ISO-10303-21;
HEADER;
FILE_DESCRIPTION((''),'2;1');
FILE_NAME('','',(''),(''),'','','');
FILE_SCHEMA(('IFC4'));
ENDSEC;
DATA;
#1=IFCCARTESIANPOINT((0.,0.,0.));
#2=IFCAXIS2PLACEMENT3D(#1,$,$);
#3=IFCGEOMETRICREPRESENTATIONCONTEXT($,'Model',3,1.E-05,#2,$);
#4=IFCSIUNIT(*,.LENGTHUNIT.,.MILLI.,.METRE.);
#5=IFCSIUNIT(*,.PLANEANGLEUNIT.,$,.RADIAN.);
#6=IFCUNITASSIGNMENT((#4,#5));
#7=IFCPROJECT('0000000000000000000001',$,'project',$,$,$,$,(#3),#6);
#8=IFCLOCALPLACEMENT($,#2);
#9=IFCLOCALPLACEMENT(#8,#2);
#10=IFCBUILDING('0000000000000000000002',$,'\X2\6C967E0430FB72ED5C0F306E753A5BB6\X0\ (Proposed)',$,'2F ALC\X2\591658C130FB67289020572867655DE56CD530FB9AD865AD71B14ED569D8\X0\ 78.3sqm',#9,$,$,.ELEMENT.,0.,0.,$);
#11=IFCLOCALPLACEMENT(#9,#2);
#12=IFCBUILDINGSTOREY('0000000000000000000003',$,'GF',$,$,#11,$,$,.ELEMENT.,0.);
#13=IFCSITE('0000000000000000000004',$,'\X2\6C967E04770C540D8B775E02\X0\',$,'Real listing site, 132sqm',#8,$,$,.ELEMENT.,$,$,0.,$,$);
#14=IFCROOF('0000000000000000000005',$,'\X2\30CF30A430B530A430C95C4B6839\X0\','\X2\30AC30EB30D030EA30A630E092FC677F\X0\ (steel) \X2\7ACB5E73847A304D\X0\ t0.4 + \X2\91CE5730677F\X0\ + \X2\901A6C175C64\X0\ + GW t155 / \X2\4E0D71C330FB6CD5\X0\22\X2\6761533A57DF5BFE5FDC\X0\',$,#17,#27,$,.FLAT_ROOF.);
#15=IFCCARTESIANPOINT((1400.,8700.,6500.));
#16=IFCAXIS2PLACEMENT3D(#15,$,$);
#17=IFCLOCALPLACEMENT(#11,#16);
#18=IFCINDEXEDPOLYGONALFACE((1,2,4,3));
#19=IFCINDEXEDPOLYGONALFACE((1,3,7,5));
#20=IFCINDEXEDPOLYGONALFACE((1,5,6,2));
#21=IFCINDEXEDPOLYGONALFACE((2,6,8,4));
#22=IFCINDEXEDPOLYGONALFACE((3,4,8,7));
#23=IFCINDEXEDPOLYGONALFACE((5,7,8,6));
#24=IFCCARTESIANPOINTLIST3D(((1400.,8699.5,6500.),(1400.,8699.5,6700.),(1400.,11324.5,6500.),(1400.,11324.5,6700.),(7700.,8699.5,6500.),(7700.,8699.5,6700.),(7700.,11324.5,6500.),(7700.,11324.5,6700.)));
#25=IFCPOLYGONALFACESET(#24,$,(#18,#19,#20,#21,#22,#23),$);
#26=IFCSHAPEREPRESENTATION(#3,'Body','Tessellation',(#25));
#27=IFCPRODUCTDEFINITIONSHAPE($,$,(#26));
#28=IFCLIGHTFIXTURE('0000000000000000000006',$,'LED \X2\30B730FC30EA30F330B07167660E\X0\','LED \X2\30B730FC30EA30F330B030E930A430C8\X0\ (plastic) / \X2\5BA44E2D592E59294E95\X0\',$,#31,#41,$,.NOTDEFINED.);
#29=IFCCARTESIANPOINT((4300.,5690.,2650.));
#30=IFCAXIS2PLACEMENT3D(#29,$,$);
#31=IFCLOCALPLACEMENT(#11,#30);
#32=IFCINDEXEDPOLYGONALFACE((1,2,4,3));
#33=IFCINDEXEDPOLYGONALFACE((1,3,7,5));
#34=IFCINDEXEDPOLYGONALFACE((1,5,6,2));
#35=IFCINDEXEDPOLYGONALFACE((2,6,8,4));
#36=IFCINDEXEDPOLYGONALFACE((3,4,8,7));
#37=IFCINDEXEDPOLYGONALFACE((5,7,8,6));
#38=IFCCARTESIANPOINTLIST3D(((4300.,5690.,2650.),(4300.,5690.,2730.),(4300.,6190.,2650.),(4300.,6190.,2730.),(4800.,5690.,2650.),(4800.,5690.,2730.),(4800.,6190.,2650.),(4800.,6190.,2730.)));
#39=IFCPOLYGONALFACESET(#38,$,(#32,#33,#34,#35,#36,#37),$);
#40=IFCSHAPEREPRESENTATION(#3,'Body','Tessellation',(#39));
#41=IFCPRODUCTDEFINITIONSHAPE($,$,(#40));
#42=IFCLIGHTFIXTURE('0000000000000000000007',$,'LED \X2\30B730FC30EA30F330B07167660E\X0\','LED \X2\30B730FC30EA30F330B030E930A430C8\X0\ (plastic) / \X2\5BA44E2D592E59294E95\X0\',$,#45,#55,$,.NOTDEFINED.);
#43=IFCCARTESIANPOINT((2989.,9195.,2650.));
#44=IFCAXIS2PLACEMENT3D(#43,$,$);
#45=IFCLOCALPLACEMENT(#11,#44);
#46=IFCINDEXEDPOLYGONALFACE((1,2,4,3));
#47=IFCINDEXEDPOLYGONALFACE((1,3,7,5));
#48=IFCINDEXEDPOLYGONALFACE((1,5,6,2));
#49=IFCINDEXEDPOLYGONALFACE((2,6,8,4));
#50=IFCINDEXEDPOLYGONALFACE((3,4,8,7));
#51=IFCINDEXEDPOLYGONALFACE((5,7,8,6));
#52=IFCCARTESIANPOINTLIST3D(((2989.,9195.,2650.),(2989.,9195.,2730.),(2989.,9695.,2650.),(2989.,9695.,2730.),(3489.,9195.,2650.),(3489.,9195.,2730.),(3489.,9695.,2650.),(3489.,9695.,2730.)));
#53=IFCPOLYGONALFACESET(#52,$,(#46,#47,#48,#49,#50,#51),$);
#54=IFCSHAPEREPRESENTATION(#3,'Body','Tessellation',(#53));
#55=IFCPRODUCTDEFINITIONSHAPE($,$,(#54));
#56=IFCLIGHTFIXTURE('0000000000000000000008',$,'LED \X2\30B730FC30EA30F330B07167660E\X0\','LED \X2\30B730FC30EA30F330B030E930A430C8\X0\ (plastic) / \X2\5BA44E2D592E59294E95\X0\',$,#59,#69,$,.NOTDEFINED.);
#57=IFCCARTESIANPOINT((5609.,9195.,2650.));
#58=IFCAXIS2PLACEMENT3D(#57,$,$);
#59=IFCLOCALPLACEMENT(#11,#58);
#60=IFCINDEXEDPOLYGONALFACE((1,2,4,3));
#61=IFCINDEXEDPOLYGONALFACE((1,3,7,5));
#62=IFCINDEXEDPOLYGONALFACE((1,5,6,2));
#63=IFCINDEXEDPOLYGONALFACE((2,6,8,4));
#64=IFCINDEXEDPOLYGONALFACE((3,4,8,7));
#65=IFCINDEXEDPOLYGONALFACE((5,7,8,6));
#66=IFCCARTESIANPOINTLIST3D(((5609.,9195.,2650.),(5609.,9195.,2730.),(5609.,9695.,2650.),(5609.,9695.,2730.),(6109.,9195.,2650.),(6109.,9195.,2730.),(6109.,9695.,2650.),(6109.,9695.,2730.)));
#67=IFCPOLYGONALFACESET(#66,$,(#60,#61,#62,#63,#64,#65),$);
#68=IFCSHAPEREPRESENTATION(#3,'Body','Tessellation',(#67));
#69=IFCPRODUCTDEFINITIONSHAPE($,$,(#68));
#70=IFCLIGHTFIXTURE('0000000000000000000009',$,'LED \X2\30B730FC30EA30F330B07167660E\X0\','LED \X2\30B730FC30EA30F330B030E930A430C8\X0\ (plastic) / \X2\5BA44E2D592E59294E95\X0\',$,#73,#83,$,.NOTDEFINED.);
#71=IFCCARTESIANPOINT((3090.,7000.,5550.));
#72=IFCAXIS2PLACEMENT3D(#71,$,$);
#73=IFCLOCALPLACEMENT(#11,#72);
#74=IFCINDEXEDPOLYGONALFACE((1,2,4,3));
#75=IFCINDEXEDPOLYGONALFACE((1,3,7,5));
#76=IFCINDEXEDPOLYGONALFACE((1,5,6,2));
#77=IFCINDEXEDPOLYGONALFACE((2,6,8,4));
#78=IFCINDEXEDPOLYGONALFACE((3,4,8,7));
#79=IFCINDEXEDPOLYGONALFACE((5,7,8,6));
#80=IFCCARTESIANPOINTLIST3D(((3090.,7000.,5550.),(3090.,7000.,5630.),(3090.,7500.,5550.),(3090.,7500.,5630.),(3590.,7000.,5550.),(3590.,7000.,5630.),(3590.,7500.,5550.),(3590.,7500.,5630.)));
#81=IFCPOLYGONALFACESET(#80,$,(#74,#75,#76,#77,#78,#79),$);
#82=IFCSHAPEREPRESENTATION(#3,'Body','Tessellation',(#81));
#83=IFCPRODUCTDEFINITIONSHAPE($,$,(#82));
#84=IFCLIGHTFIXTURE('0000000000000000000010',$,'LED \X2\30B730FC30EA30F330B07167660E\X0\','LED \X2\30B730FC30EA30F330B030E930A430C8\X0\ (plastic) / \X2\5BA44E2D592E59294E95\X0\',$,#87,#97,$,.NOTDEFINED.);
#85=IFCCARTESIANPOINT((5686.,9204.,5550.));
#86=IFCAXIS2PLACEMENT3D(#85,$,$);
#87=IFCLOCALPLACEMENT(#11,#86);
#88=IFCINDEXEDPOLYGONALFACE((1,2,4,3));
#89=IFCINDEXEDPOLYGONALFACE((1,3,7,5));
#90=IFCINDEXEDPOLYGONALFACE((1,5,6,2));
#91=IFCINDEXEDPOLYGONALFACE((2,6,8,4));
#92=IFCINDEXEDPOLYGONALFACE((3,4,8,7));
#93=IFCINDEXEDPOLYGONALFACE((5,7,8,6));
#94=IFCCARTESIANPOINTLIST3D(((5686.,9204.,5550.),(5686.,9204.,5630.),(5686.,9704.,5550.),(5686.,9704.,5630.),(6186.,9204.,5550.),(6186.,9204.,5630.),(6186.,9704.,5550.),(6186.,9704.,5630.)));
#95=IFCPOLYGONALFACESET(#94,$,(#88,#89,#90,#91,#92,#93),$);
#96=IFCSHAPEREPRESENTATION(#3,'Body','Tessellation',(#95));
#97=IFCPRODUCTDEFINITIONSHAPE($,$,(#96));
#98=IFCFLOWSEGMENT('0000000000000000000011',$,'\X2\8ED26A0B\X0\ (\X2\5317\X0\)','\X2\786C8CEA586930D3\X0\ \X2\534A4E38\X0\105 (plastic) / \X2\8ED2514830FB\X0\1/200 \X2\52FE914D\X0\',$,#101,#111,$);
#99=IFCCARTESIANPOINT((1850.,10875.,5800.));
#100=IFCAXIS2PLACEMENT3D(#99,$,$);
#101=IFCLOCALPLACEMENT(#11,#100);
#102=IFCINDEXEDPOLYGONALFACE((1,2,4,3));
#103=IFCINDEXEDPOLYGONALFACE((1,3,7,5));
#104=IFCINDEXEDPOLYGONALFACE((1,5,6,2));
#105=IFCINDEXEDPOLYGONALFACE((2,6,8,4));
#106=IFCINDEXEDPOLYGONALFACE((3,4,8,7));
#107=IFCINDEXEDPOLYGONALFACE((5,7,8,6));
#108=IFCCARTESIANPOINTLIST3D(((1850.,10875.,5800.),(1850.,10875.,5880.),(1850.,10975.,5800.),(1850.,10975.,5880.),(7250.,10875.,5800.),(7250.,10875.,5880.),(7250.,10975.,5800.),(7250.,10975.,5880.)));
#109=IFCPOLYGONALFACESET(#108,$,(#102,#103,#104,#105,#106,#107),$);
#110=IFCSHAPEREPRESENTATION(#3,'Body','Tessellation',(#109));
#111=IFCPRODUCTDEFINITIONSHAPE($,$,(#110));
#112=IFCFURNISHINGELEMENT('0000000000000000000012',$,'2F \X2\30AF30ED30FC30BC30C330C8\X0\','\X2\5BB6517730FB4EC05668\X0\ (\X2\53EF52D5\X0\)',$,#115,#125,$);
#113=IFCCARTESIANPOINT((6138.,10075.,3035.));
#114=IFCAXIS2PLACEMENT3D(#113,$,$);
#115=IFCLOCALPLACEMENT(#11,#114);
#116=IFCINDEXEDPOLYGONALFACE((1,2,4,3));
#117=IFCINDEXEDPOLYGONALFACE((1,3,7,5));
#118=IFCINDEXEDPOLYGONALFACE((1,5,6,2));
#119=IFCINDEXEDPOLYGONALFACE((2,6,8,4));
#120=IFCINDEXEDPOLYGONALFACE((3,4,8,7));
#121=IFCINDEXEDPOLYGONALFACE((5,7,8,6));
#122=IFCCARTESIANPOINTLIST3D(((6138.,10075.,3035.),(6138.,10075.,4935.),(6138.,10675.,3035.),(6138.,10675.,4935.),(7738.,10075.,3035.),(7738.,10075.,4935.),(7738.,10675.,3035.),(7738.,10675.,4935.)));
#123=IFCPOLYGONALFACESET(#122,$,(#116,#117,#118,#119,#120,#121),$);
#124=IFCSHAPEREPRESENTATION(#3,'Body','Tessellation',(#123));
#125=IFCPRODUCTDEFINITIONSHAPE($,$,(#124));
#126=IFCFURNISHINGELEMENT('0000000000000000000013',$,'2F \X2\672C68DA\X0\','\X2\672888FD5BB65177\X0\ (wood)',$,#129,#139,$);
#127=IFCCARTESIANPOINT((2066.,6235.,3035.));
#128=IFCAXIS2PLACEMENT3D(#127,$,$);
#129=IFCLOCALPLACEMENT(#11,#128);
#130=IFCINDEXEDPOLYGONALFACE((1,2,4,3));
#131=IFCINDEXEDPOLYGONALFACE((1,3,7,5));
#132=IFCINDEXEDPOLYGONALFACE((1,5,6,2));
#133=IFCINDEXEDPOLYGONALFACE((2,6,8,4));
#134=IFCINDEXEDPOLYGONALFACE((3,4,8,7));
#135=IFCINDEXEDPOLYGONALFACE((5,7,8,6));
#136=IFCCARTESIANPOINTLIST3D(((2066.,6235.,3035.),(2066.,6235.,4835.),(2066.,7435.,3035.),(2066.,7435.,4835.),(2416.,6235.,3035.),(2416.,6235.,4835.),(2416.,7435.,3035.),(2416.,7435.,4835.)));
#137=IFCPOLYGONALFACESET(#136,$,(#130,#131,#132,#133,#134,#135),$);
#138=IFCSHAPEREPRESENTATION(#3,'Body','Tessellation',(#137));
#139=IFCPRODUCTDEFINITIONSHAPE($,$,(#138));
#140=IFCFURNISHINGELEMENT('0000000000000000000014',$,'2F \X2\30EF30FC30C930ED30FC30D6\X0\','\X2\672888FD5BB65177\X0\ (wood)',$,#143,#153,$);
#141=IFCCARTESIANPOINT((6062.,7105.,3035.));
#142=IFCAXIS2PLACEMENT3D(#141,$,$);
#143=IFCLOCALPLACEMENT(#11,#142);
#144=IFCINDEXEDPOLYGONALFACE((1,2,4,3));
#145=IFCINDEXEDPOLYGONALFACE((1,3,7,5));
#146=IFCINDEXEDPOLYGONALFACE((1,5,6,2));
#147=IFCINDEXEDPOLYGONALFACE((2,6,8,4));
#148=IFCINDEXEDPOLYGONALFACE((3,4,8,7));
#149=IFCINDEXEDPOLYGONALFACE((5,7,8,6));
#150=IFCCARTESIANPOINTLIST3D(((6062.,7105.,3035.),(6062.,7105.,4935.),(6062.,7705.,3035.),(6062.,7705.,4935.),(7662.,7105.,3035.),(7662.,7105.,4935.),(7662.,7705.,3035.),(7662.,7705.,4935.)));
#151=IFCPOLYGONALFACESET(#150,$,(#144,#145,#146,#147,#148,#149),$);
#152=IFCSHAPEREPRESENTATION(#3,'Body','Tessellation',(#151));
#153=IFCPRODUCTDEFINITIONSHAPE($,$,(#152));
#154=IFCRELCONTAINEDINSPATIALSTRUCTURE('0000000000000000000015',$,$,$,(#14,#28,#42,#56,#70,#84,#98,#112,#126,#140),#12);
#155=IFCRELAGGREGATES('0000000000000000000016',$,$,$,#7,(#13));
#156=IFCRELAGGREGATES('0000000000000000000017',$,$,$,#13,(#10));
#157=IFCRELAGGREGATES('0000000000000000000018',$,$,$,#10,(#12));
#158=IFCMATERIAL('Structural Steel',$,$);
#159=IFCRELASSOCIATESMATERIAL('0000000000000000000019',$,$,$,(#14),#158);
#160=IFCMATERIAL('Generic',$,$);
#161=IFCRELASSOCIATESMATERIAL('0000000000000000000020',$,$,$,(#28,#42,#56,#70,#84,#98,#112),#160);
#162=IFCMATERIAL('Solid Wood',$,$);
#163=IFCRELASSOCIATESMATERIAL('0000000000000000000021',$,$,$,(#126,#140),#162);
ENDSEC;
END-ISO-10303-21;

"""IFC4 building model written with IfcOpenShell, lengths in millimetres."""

from ifc_helpers import new_model, si_unit, frame, frame_2d, origin, place, context, project, spatial, rectangle, extrude, material, element, save


model = new_model("IFC4")

# Units and contexts
model_context = context("Model", 3, precision=1e-05, world=origin())
ifc_project = project(units=[si_unit("LENGTHUNIT", "METRE", prefix="MILLI"), si_unit("PLANEANGLEUNIT", "RADIAN")], contexts=[model_context])

# Site, building, storey
site_placement = place(None, origin())
site = spatial("IfcSite", under=ifc_project, at=site_placement, Name="沖縄県名護市", ObjectType="Real listing site, 132sqm", CompositionType="ELEMENT", RefElevation=0.0)
building_placement = place(site_placement, origin())
building = spatial("IfcBuilding", under=site, at=building_placement, Name="沖縄・狭小の町家 (Proposed)", ObjectType="2F ALC外壁・木造在来工法・高断熱仕様 78.3sqm", CompositionType="ELEMENT", ElevationOfRefHeight=0.0, ElevationOfTerrain=0.0)
storey_placement = place(building_placement, origin())
storey = spatial("IfcBuildingStorey", under=building, at=storey_placement, Name="GF", CompositionType="ELEMENT", Elevation=0.0)

# Shared definitions
ifc_material_1 = material(Name="Solid Wood")

# Roof
ifc_material_2 = material(Name="Structural Steel")
roof_placement = place(storey_placement, frame((1400.0, 8700.0, 6500.0)))
element("IfcRoof", 1, at=roof_placement, inside=storey, material=ifc_material_2, Name="ハイサイド屋根", Description="ガルバリウム鋼板 (steel) 立平葺き t0.4 + 野地板 + 通気層 + GW t155 / 不燃・法22条区域対応", PredefinedType="FLAT_ROOF", context=model_context, shape_type="SweptSolid", body=[
    extrude(rectangle(XDim=6300.0, YDim=2625.0, at=frame_2d((3150.0, 1312.0))), frame((1400.0, 8700.0, 6500.0)), (0.0, 0.0, 1.0), 200.0),
])

# Light fixtures
ifc_material_3 = material(Name="Generic")
light_fixture_1_placement = place(storey_placement, frame((4300.0, 5690.0, 2650.0)))
element("IfcLightFixture", 2, at=light_fixture_1_placement, inside=storey, material=ifc_material_3, Name="LED シーリング照明", Description="LED シーリングライト (plastic) / 室中央天井", PredefinedType="NOTDEFINED", context=model_context, shape_type="SweptSolid", body=[
    extrude(rectangle(XDim=500.0, YDim=500.0, at=frame_2d((250.0, 250.0))), frame((4300.0, 5690.0, 2650.0)), (0.0, 0.0, 1.0), 80.0),
])
light_fixture_2_placement = place(storey_placement, frame((2989.0, 9195.0, 2650.0)))
element("IfcLightFixture", 3, at=light_fixture_2_placement, inside=storey, material=ifc_material_3, Name="LED シーリング照明", Description="LED シーリングライト (plastic) / 室中央天井", PredefinedType="NOTDEFINED", context=model_context, shape_type="SweptSolid", body=[
    extrude(rectangle(XDim=500.0, YDim=500.0, at=frame_2d((250.0, 250.0))), frame((2989.0, 9195.0, 2650.0)), (0.0, 0.0, 1.0), 80.0),
])
light_fixture_3_placement = place(storey_placement, frame((5609.0, 9195.0, 2650.0)))
element("IfcLightFixture", 4, at=light_fixture_3_placement, inside=storey, material=ifc_material_3, Name="LED シーリング照明", Description="LED シーリングライト (plastic) / 室中央天井", PredefinedType="NOTDEFINED", context=model_context, shape_type="SweptSolid", body=[
    extrude(rectangle(XDim=500.0, YDim=500.0, at=frame_2d((250.0, 250.0))), frame((5609.0, 9195.0, 2650.0)), (0.0, 0.0, 1.0), 80.0),
])
light_fixture_4_placement = place(storey_placement, frame((3090.0, 7000.0, 5550.0)))
element("IfcLightFixture", 5, at=light_fixture_4_placement, inside=storey, material=ifc_material_3, Name="LED シーリング照明", Description="LED シーリングライト (plastic) / 室中央天井", PredefinedType="NOTDEFINED", context=model_context, shape_type="SweptSolid", body=[
    extrude(rectangle(XDim=500.0, YDim=500.0, at=frame_2d((250.0, 250.0))), frame((3090.0, 7000.0, 5550.0)), (0.0, 0.0, 1.0), 80.0),
])
light_fixture_5_placement = place(storey_placement, frame((5686.0, 9204.0, 5550.0)))
element("IfcLightFixture", 6, at=light_fixture_5_placement, inside=storey, material=ifc_material_3, Name="LED シーリング照明", Description="LED シーリングライト (plastic) / 室中央天井", PredefinedType="NOTDEFINED", context=model_context, shape_type="SweptSolid", body=[
    extrude(rectangle(XDim=500.0, YDim=500.0, at=frame_2d((250.0, 250.0))), frame((5686.0, 9204.0, 5550.0)), (0.0, 0.0, 1.0), 80.0),
])

# Flow segment
flow_segment_placement = place(storey_placement, frame((1850.0, 10875.0, 5800.0)))
element("IfcFlowSegment", 7, at=flow_segment_placement, inside=storey, material=ifc_material_3, Name="軒樋 (北)", Description="硬質塩ビ 半丸105 (plastic) / 軒先・1/200 勾配", context=model_context, shape_type="SweptSolid", body=[
    extrude(rectangle(XDim=5400.0, YDim=100.0, at=frame_2d((2700.0, 50.0))), frame((1850.0, 10875.0, 5800.0)), (0.0, 0.0, 1.0), 80.0),
])

# Furnishing elements
furnishing_1_placement = place(storey_placement, frame((6138.0, 10075.0, 3035.0)))
element("IfcFurnishingElement", 8, at=furnishing_1_placement, inside=storey, material=ifc_material_3, Name="2F クローゼット", Description="家具・什器 (可動)", context=model_context, shape_type="SweptSolid", body=[
    extrude(rectangle(XDim=1600.0, YDim=600.0, at=frame_2d((800.0, 300.0))), frame((6138.0, 10075.0, 3035.0)), (0.0, 0.0, 1.0), 1900.0),
])
furnishing_2_placement = place(storey_placement, frame((2066.0, 6235.0, 3035.0)))
element("IfcFurnishingElement", 9, at=furnishing_2_placement, inside=storey, material=ifc_material_1, Name="2F 本棚", Description="木製家具 (wood)", context=model_context, shape_type="SweptSolid", body=[
    extrude(rectangle(XDim=350.0, YDim=1200.0, at=frame_2d((175.0, 600.0))), frame((2066.0, 6235.0, 3035.0)), (0.0, 0.0, 1.0), 1800.0),
])
furnishing_3_placement = place(storey_placement, frame((6062.0, 7105.0, 3035.0)))
element("IfcFurnishingElement", 10, at=furnishing_3_placement, inside=storey, material=ifc_material_1, Name="2F ワードローブ", Description="木製家具 (wood)", context=model_context, shape_type="SweptSolid", body=[
    extrude(rectangle(XDim=1600.0, YDim=600.0, at=frame_2d((800.0, 300.0))), frame((6062.0, 7105.0, 3035.0)), (0.0, 0.0, 1.0), 1900.0),
])

save(model, "model.ifc")
